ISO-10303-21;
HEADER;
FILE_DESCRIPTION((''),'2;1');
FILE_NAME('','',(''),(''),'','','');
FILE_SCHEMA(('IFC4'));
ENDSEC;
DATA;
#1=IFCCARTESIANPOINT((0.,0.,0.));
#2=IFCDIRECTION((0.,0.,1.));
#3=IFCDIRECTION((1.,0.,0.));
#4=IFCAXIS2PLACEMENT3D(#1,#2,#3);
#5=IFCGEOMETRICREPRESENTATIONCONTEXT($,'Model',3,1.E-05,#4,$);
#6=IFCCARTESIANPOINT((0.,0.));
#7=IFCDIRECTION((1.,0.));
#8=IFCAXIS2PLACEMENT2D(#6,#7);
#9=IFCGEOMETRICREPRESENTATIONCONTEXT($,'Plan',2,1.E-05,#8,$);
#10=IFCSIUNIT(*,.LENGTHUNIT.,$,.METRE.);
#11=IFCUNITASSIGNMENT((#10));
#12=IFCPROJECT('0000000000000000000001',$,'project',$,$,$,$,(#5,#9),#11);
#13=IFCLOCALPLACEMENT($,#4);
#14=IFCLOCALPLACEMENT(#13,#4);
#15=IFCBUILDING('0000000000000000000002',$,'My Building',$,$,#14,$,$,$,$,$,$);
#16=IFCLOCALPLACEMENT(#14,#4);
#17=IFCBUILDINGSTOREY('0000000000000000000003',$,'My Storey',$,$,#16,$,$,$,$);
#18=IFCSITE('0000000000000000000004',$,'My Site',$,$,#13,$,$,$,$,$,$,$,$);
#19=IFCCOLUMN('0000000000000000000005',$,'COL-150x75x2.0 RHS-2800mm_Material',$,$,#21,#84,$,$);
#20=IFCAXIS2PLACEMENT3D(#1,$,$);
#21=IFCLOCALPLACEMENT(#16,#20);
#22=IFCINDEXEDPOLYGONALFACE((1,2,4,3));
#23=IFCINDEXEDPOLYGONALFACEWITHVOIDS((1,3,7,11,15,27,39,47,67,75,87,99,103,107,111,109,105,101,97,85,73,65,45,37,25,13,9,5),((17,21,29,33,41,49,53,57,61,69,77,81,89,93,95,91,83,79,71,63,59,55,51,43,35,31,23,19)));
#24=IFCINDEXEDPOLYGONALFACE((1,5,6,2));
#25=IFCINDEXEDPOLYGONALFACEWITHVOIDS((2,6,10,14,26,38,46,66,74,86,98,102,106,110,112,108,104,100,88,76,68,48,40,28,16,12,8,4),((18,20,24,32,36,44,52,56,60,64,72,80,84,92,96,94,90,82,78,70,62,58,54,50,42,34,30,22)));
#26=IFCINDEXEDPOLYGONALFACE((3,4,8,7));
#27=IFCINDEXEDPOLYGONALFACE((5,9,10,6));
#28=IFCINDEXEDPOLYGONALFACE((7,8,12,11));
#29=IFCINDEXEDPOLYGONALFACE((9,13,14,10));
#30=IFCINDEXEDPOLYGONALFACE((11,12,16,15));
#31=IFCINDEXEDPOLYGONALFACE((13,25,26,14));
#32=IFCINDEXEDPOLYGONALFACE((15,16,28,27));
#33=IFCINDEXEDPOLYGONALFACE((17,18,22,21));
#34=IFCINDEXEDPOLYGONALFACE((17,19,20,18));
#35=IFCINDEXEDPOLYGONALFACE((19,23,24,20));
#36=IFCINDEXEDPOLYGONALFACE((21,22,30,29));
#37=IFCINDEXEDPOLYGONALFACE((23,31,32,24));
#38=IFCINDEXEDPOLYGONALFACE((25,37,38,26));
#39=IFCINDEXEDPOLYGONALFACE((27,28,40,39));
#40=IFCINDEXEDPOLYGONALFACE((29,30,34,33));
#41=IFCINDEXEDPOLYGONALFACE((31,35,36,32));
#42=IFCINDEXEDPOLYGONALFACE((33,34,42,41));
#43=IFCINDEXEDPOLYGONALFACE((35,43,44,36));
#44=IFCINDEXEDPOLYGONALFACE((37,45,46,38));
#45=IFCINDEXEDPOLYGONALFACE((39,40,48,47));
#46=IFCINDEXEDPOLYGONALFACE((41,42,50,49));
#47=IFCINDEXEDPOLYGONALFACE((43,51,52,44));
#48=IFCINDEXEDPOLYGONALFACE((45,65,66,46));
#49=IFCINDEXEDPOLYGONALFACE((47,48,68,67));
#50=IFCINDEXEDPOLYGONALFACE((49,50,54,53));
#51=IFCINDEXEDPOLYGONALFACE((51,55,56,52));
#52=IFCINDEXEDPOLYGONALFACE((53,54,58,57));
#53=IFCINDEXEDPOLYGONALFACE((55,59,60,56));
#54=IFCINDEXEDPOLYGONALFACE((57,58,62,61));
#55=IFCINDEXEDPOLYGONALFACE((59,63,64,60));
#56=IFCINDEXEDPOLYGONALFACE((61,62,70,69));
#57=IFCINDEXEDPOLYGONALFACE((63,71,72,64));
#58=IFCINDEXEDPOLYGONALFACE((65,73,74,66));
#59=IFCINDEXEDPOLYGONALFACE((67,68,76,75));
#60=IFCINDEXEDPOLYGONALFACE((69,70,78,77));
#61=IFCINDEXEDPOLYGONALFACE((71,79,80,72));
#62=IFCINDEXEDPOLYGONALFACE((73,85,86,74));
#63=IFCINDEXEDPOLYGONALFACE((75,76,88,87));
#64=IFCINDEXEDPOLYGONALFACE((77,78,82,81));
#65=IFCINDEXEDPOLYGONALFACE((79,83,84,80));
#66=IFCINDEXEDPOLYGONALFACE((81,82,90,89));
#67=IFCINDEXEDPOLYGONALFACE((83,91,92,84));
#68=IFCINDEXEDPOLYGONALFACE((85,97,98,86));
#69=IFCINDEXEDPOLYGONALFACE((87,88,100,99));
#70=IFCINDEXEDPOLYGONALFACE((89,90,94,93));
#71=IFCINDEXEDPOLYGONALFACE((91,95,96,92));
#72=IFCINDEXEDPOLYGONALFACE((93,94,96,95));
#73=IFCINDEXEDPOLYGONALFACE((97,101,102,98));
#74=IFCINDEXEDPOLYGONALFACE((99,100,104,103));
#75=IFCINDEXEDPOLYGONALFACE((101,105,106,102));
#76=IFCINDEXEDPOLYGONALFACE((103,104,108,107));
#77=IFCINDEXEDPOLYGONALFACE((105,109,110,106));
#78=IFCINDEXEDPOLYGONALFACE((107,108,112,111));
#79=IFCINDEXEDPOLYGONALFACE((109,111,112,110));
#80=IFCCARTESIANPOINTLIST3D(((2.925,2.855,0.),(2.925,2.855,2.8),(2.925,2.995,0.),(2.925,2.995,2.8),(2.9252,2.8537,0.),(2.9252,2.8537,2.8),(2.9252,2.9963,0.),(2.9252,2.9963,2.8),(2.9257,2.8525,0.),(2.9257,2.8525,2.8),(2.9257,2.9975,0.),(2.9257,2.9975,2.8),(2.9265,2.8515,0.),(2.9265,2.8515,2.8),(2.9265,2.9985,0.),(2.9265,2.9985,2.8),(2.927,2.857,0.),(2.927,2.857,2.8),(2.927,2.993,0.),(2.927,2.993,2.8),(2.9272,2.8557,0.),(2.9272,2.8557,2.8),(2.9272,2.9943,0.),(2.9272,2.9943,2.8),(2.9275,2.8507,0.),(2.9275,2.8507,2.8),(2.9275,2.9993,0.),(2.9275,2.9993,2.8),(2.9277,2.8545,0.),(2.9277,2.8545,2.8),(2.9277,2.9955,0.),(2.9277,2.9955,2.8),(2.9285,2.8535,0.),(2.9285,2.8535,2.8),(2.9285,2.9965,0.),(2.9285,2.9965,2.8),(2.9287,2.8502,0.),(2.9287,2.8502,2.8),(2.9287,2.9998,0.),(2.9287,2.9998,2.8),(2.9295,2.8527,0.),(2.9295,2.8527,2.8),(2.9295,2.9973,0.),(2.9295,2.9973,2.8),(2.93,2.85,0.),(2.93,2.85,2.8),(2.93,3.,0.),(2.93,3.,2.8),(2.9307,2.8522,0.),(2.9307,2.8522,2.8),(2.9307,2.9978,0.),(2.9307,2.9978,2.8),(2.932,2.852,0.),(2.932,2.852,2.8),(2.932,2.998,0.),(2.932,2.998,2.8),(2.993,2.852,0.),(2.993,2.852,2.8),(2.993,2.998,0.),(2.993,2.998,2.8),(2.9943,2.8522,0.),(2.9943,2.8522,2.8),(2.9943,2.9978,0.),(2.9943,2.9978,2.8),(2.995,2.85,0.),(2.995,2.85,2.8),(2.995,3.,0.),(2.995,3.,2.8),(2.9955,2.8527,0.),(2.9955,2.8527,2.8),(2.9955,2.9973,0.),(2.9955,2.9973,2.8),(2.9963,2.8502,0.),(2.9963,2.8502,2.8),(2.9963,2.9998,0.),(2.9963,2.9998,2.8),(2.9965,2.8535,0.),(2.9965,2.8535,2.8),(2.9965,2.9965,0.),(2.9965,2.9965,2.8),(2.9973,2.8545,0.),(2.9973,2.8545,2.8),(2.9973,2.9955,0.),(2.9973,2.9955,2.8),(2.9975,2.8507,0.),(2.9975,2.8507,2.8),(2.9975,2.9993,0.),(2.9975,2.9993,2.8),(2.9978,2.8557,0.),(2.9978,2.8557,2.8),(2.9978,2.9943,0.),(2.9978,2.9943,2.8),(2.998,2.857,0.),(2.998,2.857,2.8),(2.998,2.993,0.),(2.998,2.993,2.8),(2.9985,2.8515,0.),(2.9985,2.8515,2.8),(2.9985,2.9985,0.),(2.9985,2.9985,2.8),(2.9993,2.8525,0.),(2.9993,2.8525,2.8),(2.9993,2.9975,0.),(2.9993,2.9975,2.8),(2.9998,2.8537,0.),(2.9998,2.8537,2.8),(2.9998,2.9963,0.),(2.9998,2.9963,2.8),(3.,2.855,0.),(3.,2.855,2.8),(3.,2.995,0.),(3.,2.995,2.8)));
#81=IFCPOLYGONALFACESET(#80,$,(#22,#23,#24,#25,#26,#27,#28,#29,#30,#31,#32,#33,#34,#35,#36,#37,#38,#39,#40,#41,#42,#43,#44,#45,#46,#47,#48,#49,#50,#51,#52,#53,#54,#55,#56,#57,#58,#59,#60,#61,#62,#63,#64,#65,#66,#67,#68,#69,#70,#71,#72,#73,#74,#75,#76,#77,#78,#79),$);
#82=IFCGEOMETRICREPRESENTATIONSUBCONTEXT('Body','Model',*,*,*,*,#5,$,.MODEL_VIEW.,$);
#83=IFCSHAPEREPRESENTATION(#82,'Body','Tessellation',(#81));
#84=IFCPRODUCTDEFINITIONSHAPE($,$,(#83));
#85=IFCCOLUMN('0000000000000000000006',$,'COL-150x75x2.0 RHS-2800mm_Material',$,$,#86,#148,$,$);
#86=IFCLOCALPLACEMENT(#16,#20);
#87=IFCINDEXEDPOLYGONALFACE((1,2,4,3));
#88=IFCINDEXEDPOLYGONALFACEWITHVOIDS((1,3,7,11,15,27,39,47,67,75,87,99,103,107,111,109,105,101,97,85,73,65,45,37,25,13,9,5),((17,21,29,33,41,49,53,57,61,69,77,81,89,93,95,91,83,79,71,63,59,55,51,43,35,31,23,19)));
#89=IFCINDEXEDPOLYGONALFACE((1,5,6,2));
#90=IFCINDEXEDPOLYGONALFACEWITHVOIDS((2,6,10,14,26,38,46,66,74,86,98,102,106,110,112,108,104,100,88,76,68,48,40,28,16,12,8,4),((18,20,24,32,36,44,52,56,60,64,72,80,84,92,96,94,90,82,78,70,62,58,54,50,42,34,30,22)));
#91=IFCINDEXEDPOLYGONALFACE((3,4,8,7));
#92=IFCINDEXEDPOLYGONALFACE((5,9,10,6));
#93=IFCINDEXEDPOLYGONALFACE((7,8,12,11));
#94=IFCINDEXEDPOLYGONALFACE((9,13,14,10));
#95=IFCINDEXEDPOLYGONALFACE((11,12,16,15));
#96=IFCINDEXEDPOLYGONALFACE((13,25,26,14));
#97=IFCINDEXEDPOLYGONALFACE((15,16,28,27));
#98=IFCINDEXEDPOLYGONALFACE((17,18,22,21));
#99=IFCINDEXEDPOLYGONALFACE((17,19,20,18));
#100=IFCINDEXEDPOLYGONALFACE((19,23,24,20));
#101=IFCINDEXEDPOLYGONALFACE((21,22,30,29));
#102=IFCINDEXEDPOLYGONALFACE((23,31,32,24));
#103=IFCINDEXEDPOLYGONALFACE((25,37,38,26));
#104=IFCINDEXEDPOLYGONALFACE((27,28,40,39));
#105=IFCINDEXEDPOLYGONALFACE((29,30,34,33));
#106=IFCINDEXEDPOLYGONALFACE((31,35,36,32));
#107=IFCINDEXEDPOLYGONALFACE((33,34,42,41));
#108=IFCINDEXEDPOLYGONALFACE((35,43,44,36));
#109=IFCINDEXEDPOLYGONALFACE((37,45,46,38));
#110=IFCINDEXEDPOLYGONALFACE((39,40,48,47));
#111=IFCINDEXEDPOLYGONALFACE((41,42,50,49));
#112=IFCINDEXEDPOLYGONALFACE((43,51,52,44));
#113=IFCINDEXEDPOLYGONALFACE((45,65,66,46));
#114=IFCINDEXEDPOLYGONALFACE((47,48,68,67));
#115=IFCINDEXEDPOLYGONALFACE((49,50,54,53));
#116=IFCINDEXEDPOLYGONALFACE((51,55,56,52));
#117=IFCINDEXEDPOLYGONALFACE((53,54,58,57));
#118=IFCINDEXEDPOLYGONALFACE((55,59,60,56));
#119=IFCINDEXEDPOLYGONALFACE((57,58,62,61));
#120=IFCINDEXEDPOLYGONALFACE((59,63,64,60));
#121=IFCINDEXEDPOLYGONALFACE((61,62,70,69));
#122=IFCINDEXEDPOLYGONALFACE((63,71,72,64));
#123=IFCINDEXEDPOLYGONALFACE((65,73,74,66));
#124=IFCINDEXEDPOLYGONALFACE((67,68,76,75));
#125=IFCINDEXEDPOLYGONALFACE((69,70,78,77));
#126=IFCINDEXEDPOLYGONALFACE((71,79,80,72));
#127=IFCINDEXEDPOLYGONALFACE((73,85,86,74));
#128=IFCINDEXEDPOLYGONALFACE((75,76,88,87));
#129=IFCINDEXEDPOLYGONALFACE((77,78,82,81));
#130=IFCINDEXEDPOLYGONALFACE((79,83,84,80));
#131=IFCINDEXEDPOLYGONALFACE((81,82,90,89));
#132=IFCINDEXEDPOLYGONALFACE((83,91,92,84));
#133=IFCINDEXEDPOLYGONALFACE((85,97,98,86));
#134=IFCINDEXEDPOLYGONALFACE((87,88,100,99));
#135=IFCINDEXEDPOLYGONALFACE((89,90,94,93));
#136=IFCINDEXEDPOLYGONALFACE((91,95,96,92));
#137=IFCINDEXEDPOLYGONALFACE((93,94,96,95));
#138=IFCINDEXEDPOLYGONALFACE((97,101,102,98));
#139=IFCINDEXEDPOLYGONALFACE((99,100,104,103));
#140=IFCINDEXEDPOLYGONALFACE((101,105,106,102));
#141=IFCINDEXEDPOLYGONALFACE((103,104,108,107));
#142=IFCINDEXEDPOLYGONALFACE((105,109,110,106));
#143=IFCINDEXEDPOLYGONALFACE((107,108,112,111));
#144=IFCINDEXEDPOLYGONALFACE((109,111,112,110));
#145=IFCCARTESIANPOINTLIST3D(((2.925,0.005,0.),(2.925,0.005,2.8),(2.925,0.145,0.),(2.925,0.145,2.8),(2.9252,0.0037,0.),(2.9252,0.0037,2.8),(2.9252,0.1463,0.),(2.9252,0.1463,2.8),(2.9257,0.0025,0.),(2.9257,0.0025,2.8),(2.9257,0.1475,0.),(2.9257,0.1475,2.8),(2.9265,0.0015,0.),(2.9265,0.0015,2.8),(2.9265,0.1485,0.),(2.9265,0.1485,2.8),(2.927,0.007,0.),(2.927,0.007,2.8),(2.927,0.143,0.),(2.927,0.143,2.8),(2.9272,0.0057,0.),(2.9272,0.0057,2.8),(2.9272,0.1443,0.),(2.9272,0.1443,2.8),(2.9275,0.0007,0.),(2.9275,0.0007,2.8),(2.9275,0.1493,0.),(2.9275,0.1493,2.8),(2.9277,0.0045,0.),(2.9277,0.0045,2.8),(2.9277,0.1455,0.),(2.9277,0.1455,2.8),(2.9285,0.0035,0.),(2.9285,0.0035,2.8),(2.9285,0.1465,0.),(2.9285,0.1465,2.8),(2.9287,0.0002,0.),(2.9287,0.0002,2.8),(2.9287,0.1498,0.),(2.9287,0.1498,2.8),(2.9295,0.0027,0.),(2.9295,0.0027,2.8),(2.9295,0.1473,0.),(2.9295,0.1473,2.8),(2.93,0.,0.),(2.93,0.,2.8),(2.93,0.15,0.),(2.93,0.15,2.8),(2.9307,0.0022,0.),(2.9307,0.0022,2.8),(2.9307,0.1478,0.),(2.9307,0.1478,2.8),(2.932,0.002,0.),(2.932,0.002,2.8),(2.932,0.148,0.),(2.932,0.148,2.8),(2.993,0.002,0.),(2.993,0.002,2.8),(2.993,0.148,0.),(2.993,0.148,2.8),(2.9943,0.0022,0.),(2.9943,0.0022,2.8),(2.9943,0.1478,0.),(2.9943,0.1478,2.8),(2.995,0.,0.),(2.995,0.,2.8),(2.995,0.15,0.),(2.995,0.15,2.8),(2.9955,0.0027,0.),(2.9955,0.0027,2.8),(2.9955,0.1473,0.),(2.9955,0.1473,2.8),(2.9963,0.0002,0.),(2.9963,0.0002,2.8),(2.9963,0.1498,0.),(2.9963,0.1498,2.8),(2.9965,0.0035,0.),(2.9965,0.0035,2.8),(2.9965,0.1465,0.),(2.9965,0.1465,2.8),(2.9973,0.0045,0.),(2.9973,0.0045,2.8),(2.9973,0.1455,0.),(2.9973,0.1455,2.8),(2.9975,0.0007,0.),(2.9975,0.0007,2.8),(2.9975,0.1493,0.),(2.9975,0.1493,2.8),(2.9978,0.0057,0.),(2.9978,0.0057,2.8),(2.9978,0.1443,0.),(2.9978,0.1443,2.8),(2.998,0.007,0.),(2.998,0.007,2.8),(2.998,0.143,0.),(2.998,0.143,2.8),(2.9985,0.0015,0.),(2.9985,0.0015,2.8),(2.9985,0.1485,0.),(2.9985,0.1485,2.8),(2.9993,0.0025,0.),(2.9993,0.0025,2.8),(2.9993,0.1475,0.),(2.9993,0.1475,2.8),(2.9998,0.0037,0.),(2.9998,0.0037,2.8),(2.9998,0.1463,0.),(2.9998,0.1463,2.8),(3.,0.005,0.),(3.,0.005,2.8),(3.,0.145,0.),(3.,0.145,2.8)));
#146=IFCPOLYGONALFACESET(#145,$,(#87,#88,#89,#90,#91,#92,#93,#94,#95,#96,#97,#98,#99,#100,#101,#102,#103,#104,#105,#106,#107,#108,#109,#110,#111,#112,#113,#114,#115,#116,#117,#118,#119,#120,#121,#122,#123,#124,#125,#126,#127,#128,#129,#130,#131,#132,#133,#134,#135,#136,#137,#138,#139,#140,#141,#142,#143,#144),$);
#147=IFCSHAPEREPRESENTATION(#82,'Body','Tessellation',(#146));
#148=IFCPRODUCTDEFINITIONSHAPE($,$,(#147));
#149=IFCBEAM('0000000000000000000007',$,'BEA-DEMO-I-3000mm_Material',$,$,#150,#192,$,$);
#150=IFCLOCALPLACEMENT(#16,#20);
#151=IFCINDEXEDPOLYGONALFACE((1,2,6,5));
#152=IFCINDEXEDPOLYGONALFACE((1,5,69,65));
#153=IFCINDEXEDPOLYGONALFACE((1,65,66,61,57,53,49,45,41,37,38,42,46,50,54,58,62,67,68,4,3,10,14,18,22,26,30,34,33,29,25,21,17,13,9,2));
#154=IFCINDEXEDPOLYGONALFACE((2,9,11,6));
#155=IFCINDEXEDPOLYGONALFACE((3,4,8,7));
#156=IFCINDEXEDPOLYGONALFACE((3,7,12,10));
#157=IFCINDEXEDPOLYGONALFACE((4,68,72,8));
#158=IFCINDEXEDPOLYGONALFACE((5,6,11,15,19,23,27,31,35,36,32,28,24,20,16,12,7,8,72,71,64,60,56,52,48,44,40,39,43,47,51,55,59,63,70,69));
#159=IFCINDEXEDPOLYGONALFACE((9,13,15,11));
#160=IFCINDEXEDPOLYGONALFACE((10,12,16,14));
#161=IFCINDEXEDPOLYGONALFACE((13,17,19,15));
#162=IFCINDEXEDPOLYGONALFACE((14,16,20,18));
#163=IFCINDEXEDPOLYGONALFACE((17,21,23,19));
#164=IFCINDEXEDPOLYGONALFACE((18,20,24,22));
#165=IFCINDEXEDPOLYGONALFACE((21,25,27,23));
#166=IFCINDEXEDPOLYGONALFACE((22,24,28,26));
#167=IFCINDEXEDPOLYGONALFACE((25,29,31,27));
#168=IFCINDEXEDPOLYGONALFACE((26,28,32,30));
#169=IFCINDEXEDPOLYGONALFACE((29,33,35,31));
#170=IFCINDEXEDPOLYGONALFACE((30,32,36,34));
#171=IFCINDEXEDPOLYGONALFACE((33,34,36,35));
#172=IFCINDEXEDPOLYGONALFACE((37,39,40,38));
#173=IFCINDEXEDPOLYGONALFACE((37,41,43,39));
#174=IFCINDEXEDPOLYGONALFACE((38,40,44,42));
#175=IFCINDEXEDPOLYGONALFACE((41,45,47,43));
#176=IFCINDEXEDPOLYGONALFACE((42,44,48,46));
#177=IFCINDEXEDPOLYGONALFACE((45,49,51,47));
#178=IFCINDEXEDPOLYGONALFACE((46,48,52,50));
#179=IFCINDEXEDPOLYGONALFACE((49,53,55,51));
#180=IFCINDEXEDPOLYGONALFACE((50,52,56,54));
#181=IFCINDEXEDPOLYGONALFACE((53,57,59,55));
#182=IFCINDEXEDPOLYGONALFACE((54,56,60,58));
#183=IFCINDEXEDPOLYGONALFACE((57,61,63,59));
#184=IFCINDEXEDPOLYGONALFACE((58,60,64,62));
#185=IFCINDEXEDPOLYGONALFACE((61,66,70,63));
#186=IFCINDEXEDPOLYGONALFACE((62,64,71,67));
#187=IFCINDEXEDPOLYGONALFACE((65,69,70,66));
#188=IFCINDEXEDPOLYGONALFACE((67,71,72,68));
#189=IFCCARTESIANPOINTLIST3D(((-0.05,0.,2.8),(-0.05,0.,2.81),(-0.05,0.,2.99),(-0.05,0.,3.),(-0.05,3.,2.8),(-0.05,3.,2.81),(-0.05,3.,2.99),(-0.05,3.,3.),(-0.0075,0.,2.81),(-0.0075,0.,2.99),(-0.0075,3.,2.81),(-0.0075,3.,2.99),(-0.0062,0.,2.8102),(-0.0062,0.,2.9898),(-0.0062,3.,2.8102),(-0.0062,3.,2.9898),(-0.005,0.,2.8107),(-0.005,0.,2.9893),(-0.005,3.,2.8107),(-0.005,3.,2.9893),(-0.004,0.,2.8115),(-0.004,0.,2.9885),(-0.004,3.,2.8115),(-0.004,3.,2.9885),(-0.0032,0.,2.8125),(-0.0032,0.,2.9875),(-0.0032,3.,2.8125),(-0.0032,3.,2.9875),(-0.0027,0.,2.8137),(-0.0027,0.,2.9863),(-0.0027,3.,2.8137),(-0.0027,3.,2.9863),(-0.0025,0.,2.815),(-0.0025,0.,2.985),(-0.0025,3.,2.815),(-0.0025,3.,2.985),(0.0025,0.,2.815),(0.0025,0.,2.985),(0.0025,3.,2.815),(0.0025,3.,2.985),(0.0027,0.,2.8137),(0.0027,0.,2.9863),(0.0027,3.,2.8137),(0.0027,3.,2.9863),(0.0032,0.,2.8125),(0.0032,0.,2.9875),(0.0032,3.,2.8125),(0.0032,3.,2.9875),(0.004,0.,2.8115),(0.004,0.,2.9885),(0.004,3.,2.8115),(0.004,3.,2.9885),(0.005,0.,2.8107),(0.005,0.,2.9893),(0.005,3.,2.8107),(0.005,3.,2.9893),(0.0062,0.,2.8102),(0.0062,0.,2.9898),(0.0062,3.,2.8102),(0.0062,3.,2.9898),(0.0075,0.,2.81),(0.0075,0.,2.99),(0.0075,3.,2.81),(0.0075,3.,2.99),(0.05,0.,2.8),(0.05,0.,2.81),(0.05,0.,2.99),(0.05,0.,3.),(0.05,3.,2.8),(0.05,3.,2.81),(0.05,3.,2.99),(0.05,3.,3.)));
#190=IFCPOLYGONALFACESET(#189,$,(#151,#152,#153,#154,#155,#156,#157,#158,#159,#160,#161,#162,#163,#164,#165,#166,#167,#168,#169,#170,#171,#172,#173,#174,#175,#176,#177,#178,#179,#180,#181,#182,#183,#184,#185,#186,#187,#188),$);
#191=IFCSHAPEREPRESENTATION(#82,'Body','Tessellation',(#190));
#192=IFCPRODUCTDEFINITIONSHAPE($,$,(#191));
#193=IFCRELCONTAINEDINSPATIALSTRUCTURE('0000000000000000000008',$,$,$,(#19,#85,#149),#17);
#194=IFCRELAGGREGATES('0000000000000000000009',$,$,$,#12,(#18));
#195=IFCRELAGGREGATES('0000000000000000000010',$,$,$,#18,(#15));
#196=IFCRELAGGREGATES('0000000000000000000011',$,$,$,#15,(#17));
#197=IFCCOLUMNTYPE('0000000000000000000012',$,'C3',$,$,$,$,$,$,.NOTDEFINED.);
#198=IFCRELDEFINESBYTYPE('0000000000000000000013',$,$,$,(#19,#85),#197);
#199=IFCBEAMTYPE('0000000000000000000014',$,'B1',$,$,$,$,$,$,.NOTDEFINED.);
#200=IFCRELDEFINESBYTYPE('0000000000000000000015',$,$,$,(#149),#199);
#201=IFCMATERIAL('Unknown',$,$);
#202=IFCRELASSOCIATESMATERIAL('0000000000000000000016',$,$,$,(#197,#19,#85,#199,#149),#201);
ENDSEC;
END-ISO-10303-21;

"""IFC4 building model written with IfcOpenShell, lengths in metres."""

from ifc_helpers import new_model, si_unit, frame, origin_with_axes, origin_2d_with_axis, place, context, subcontext, project, spatial, hollow_rectangle, i_section, extrude, material, material_profile, profile_set, profile_usage, type_object, element, save


model = new_model("IFC4")

# Units and contexts
model_context = context("Model", 3, precision=1e-05, world=origin_with_axes())
plan_context = context("Plan", 2, precision=1e-05, world=origin_2d_with_axis())
body_context = subcontext(model_context, "Body", "Model", "MODEL_VIEW")
ifc_project = project(units=[si_unit("LENGTHUNIT", "METRE")], contexts=[model_context, plan_context])

# Site, building, storey
site_placement = place(None, origin_with_axes())
site = spatial("IfcSite", under=ifc_project, at=site_placement, Name="My Site")
building_placement = place(site_placement, origin_with_axes())
building = spatial("IfcBuilding", under=site, at=building_placement, Name="My Building")
storey_placement = place(building_placement, origin_with_axes())
storey = spatial("IfcBuildingStorey", under=building, at=storey_placement, Name="My Storey")

# Columns
ifc_material_1 = material(Name="Unknown")
ifc_material_profile_1 = material_profile(ifc_material_1, hollow_rectangle(XDim=0.075, YDim=0.15, WallThickness=0.002, InnerFilletRadius=0.005, OuterFilletRadius=0.005))
ifc_profile_set_1 = profile_set([ifc_material_profile_1])
column_type = type_object("IfcColumnType", Name="C3", PredefinedType="NOTDEFINED", material=ifc_profile_set_1)
ifc_profile_usage_1 = profile_usage(ifc_profile_set_1, cardinal=9)
column_1_placement = place(storey_placement, frame((3.0, 3.0, 0.0), z_axis=(0.0, 0.0, 1.0), x_axis=(1.0, 0.0, 0.0)))
element("IfcColumn", 1, at=column_1_placement, inside=storey, type_object=column_type, material=ifc_profile_usage_1, Name="COL-150x75x2.0 RHS-2800mm_Material", context=body_context, shape_type="SweptSolid", body=[
    extrude(hollow_rectangle(XDim=0.075, YDim=0.15, WallThickness=0.002, InnerFilletRadius=0.005, OuterFilletRadius=0.005), frame((-0.0375, -0.075, 0.0)), (0.0, 0.0, 1.0), 2.8),
])
ifc_profile_usage_2 = profile_usage(ifc_profile_set_1, cardinal=3)
column_2_placement = place(storey_placement, frame((3.0, 0.0, 0.0), z_axis=(0.0, 0.0, 1.0), x_axis=(1.0, 0.0, 0.0)))
element("IfcColumn", 2, at=column_2_placement, inside=storey, type_object=column_type, material=ifc_profile_usage_2, Name="COL-150x75x2.0 RHS-2800mm_Material", context=body_context, shape_type="SweptSolid", body=[
    extrude(hollow_rectangle(XDim=0.075, YDim=0.15, WallThickness=0.002, InnerFilletRadius=0.005, OuterFilletRadius=0.005), frame((-0.0375, 0.075, 0.0)), (0.0, 0.0, 1.0), 2.8),
])

# Beam
ifc_material_profile_2 = material_profile(ifc_material_1, i_section(OverallWidth=0.1, OverallDepth=0.2, WebThickness=0.005, FlangeThickness=0.01, FilletRadius=0.005))
ifc_profile_set_2 = profile_set([ifc_material_profile_2])
ifc_profile_usage_3 = profile_usage(ifc_profile_set_2, cardinal=8)
beam_type = type_object("IfcBeamType", Name="B1", PredefinedType="NOTDEFINED", material=ifc_profile_set_2)
beam_1_placement = place(storey_placement, frame((0.0, 0.0, 3.0), z_axis=(0.0, 1.0, 0.0), x_axis=(-1.0, 0.0, 0.0)))
element("IfcBeam", 3, at=beam_1_placement, inside=storey, type_object=beam_type, material=ifc_profile_usage_3, Name="BEA-DEMO-I-3000mm_Material", context=body_context, shape_type="SweptSolid", body=[
    extrude(i_section(OverallWidth=0.1, OverallDepth=0.2, WebThickness=0.005, FlangeThickness=0.01, FilletRadius=0.005), frame((0.0, -0.1, 0.0)), (0.0, 0.0, 1.0), 3.0),
])

save(model, "model.ifc")
